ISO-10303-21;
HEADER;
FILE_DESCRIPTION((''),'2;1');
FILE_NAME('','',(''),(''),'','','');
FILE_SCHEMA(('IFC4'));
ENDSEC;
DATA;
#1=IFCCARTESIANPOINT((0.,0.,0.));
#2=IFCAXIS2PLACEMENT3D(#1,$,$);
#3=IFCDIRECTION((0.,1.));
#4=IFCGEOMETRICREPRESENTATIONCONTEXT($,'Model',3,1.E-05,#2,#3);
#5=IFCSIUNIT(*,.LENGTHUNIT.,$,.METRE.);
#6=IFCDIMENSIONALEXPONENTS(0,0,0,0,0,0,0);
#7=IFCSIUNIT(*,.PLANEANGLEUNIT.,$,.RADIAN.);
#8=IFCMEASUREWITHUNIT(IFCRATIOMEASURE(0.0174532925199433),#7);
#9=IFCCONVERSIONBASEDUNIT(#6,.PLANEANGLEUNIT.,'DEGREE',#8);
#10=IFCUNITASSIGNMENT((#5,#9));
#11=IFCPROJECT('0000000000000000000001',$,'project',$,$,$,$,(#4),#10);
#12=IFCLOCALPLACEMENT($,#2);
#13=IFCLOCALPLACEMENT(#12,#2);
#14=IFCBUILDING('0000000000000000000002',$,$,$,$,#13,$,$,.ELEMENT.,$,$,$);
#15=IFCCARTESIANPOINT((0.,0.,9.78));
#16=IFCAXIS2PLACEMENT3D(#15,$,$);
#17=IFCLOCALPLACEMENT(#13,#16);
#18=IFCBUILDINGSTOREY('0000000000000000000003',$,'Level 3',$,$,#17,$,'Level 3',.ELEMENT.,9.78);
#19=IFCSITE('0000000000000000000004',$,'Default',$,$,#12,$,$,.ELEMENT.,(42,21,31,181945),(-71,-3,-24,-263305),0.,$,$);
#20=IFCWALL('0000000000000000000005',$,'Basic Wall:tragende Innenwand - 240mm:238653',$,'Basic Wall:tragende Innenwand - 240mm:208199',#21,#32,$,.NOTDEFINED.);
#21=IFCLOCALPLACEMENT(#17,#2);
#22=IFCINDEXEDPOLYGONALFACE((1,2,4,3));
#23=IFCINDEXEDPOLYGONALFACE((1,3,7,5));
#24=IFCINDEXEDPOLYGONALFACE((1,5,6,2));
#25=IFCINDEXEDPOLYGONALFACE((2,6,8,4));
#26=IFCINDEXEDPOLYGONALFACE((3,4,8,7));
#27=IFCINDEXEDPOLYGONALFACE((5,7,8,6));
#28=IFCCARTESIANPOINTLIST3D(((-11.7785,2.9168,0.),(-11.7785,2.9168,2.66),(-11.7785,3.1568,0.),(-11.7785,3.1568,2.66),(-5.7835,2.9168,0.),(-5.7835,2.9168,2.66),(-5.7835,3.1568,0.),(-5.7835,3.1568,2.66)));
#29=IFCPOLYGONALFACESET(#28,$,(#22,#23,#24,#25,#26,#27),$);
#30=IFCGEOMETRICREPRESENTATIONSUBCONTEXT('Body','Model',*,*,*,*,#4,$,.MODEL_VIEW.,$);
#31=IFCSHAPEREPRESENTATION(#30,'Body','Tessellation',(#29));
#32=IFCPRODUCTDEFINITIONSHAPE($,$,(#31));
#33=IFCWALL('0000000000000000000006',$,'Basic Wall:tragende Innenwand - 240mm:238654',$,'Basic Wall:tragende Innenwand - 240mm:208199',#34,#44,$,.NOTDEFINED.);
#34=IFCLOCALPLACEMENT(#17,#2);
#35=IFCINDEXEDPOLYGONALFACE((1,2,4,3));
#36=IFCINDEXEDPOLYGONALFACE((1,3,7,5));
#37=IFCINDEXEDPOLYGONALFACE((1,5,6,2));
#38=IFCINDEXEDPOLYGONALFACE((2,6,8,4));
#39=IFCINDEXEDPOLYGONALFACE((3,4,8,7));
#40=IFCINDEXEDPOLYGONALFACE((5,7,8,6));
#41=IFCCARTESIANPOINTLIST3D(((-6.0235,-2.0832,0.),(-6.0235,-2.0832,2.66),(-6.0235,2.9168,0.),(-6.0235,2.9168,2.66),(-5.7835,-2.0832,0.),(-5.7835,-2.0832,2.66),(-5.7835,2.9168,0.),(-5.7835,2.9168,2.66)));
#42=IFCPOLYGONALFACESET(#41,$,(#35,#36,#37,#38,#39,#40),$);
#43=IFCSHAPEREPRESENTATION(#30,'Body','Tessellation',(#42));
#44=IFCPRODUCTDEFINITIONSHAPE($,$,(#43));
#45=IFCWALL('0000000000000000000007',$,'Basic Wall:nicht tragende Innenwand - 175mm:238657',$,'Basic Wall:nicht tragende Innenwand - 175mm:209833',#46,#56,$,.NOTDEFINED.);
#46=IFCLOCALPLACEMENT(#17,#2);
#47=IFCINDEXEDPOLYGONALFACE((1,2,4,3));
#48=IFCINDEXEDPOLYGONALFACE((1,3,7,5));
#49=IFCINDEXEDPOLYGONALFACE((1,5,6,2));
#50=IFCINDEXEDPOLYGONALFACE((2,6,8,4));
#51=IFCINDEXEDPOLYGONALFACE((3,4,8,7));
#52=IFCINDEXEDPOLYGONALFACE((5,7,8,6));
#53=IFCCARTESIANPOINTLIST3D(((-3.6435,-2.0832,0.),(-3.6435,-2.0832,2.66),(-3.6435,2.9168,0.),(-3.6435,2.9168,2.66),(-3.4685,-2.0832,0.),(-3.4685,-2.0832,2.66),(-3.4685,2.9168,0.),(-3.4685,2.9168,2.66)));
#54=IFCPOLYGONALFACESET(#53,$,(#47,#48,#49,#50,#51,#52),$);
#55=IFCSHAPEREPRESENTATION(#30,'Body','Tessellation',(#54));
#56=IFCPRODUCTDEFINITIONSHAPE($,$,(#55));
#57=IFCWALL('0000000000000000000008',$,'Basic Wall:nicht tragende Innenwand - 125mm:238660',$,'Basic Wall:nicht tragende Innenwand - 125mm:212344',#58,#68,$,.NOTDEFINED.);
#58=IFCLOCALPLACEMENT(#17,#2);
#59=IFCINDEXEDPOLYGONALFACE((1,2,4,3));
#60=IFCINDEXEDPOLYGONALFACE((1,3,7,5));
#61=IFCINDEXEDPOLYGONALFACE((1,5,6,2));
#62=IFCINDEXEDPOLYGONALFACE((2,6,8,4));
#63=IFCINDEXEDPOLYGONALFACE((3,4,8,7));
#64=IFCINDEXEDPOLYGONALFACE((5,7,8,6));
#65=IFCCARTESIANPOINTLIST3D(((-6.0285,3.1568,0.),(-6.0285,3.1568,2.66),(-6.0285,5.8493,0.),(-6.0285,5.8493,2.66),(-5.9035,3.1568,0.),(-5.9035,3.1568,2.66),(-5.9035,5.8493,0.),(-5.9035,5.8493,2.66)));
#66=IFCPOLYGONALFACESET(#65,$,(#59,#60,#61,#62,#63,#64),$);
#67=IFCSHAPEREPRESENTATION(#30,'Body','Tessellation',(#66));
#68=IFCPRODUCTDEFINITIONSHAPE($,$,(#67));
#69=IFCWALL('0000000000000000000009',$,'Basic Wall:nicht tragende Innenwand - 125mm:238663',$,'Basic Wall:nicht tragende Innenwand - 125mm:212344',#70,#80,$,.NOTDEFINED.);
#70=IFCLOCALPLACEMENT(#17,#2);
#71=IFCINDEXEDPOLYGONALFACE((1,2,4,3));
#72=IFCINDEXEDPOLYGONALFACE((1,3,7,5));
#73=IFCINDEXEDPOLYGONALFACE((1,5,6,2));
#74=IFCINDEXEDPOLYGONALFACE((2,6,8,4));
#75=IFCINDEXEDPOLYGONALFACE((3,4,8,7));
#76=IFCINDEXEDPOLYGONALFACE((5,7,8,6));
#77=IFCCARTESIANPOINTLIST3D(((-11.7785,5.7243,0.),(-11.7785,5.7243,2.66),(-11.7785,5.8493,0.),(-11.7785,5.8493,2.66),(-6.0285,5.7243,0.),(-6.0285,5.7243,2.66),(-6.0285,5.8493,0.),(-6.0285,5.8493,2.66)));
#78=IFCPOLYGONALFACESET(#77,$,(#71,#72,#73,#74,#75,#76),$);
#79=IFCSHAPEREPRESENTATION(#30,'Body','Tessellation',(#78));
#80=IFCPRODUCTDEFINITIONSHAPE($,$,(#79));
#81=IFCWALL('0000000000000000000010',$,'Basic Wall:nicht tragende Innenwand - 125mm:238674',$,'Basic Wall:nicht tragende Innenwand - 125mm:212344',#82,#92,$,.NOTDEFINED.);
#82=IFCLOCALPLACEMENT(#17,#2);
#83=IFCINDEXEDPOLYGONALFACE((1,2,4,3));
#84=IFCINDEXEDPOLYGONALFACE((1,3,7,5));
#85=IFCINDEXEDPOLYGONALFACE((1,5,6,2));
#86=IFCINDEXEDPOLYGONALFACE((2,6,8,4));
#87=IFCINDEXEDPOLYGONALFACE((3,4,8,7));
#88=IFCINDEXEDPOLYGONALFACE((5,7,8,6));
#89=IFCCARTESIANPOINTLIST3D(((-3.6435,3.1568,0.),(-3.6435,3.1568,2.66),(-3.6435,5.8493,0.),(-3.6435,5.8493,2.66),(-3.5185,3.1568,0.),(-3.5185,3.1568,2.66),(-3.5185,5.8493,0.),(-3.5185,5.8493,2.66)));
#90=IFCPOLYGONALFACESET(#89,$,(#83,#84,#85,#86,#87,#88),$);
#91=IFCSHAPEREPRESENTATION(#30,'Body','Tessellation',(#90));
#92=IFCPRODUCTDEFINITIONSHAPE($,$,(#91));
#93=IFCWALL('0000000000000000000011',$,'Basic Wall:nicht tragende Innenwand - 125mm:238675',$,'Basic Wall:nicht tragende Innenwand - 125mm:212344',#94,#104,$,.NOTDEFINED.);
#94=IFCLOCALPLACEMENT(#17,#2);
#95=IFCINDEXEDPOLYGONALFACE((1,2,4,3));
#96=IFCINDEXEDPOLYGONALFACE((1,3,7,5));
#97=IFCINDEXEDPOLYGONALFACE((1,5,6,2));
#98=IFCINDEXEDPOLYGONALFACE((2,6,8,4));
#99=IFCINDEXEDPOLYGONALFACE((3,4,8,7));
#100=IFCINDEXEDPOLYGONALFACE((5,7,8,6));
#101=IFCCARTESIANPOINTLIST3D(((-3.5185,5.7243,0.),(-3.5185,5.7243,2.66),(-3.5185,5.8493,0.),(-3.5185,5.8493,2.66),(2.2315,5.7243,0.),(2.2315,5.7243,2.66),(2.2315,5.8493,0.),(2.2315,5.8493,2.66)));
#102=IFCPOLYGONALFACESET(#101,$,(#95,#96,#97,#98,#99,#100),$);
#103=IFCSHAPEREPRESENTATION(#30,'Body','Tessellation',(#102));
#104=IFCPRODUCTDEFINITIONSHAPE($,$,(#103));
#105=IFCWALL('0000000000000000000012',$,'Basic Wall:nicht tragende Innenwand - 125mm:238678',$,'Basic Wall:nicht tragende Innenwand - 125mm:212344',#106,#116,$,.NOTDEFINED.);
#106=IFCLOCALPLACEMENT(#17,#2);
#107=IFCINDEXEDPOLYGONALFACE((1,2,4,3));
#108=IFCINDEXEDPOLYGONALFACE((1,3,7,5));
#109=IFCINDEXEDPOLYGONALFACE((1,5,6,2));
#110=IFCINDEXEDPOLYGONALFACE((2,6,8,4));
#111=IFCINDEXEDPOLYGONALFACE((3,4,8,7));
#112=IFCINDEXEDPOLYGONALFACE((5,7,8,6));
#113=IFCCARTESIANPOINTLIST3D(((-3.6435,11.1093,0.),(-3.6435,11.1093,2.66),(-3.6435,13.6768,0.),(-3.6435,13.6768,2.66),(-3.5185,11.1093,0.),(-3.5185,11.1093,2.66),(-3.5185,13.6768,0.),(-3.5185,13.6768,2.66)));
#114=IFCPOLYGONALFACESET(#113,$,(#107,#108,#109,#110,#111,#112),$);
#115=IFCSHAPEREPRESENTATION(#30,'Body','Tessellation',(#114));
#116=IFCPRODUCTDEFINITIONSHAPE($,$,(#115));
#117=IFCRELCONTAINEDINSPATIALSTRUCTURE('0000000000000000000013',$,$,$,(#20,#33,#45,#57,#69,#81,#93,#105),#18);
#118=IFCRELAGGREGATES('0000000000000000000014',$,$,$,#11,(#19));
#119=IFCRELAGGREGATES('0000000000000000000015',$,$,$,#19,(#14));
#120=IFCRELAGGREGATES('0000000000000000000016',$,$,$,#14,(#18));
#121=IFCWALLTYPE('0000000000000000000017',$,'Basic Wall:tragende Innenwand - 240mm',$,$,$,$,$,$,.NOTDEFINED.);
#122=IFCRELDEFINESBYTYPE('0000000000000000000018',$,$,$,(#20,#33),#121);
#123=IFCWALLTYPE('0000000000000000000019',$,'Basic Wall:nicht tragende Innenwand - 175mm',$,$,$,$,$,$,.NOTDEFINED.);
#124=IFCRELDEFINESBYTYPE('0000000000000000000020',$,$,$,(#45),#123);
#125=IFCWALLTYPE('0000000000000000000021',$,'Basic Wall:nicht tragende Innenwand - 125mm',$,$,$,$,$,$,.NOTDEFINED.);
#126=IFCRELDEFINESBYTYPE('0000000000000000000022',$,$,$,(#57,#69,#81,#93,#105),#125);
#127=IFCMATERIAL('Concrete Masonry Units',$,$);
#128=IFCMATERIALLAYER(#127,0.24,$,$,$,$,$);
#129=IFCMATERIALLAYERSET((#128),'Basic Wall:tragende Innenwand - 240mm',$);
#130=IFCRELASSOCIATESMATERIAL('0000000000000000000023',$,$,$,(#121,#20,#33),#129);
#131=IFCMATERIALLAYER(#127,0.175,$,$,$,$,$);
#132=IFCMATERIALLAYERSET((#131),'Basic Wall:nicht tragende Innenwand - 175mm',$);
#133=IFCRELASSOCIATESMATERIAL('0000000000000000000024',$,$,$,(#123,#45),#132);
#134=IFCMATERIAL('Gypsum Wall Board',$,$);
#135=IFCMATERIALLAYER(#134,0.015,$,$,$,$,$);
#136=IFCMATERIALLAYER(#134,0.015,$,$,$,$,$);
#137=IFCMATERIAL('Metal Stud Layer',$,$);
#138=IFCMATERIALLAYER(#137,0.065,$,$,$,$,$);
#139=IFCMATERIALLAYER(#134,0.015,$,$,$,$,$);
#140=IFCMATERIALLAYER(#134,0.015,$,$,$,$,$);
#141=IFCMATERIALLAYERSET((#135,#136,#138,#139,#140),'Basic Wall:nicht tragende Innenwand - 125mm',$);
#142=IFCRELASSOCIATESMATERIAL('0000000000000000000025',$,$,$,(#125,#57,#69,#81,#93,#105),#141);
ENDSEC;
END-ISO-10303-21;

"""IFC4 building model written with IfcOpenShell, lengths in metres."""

from ifc_helpers import new_model, entity, si_unit, converted_unit, direction, frame, frame_2d, origin, place, context, subcontext, project, spatial, rectangle, extrude, material, layer, layer_set, layer_usage, type_object, element, save


model = new_model("IFC4")

# Units and contexts
model_context = context("Model", 3, precision=1e-05, world=origin(), true_north=direction((0.0, 1.0)))
body_context = subcontext(model_context, "Body", "Model", "MODEL_VIEW")
ifc_project = project(units=[si_unit("LENGTHUNIT", "METRE"), converted_unit("PLANEANGLEUNIT", "DEGREE", entity("IfcRatioMeasure", 0.0174532925199433), si_unit("PLANEANGLEUNIT", "RADIAN"), dimensions=[0, 0, 0, 0, 0, 0, 0])], contexts=[model_context])

# Site, building, storey
site_placement = place(None, origin())
site = spatial("IfcSite", under=ifc_project, at=site_placement, Name="Default", CompositionType="ELEMENT", RefLatitude=(42, 21, 31, 181945), RefLongitude=(-71, -3, -24, -263305), RefElevation=0.0)
building_placement = place(site_placement, origin())
building = spatial("IfcBuilding", under=site, at=building_placement, CompositionType="ELEMENT")
storey_placement = place(building_placement, frame((0.0, 0.0, 9.78)))
storey = spatial("IfcBuildingStorey", under=building, at=storey_placement, Name="Level 3", LongName="Level 3", CompositionType="ELEMENT", Elevation=9.78)

# Walls
ifc_material_1 = material(Name="Concrete Masonry Units")
ifc_layer_1 = layer(ifc_material_1, 0.24)
ifc_layer_set_1 = layer_set([ifc_layer_1], Name="Basic Wall:tragende Innenwand - 240mm")
ifc_layer_usage_1 = layer_usage(ifc_layer_set_1, "AXIS2", "NEGATIVE", 0.12)
wall_type_1 = type_object("IfcWallType", Name="Basic Wall:tragende Innenwand - 240mm", PredefinedType="NOTDEFINED", material=ifc_layer_set_1)
wall_1_placement = place(storey_placement, frame((-11.7785, 3.0368, 0.0)))
element("IfcWall", 1, at=wall_1_placement, inside=storey, type_object=wall_type_1, material=ifc_layer_usage_1, Name="Basic Wall:tragende Innenwand - 240mm:238653", ObjectType="Basic Wall:tragende Innenwand - 240mm:208199", PredefinedType="NOTDEFINED", context=body_context, shape_type="SweptSolid", body=[
    extrude(rectangle(XDim=5.995, YDim=0.24, at=frame_2d((2.9975, 0.0), x_axis=(-1.0, 0.0))), origin(), (0.0, 0.0, 1.0), 2.66),
])
ifc_layer_usage_2 = layer_usage(ifc_layer_set_1, "AXIS2", "NEGATIVE", 0.12)
wall_2_placement = place(storey_placement, frame((-5.9035, 2.9168, 0.0), z_axis=(0.0, 0.0, 1.0), x_axis=(0.0, -1.0, 0.0)))
element("IfcWall", 2, at=wall_2_placement, inside=storey, type_object=wall_type_1, material=ifc_layer_usage_2, Name="Basic Wall:tragende Innenwand - 240mm:238654", ObjectType="Basic Wall:tragende Innenwand - 240mm:208199", PredefinedType="NOTDEFINED", context=body_context, shape_type="SweptSolid", body=[
    extrude(rectangle(XDim=5.0, YDim=0.24, at=frame_2d((2.5, 0.0), x_axis=(-1.0, 0.0))), origin(), (0.0, 0.0, 1.0), 2.66),
])
ifc_layer_2 = layer(ifc_material_1, 0.175)
ifc_layer_set_2 = layer_set([ifc_layer_2], Name="Basic Wall:nicht tragende Innenwand - 175mm")
ifc_layer_usage_3 = layer_usage(ifc_layer_set_2, "AXIS2", "NEGATIVE", 0.0875)
wall_type_2 = type_object("IfcWallType", Name="Basic Wall:nicht tragende Innenwand - 175mm", PredefinedType="NOTDEFINED", material=ifc_layer_set_2)
wall_3_placement = place(storey_placement, frame((-3.556, 2.9168, 0.0), z_axis=(0.0, 0.0, 1.0), x_axis=(0.0, -1.0, 0.0)))
element("IfcWall", 3, at=wall_3_placement, inside=storey, type_object=wall_type_2, material=ifc_layer_usage_3, Name="Basic Wall:nicht tragende Innenwand - 175mm:238657", ObjectType="Basic Wall:nicht tragende Innenwand - 175mm:209833", PredefinedType="NOTDEFINED", context=body_context, shape_type="SweptSolid", body=[
    extrude(rectangle(XDim=5.0, YDim=0.175, at=frame_2d((2.5, 0.0), x_axis=(-1.0, 0.0))), origin(), (0.0, 0.0, 1.0), 2.66),
])
ifc_material_2 = material(Name="Gypsum Wall Board")
ifc_layer_3 = layer(ifc_material_2, 0.015)
ifc_layer_4 = layer(ifc_material_2, 0.015)
ifc_material_3 = material(Name="Metal Stud Layer")
ifc_layer_5 = layer(ifc_material_3, 0.065)
ifc_layer_6 = layer(ifc_material_2, 0.015)
ifc_layer_7 = layer(ifc_material_2, 0.015)
ifc_layer_set_3 = layer_set([ifc_layer_3, ifc_layer_4, ifc_layer_5, ifc_layer_6, ifc_layer_7], Name="Basic Wall:nicht tragende Innenwand - 125mm")
ifc_layer_usage_4 = layer_usage(ifc_layer_set_3, "AXIS2", "NEGATIVE", 0.0625)
wall_type_3 = type_object("IfcWallType", Name="Basic Wall:nicht tragende Innenwand - 125mm", PredefinedType="NOTDEFINED", material=ifc_layer_set_3)
wall_4_placement = place(storey_placement, frame((-5.966, 5.8493, 0.0), z_axis=(0.0, 0.0, 1.0), x_axis=(0.0, -1.0, 0.0)))
element("IfcWall", 4, at=wall_4_placement, inside=storey, type_object=wall_type_3, material=ifc_layer_usage_4, Name="Basic Wall:nicht tragende Innenwand - 125mm:238660", ObjectType="Basic Wall:nicht tragende Innenwand - 125mm:212344", PredefinedType="NOTDEFINED", context=body_context, shape_type="SweptSolid", body=[
    extrude(rectangle(XDim=2.6925, YDim=0.125, at=frame_2d((1.3462, 0.0), x_axis=(-1.0, 0.0))), origin(), (0.0, 0.0, 1.0), 2.66),
])
ifc_layer_usage_5 = layer_usage(ifc_layer_set_3, "AXIS2", "NEGATIVE", 0.0625)
wall_5_placement = place(storey_placement, frame((-6.0285, 5.7868, 0.0), z_axis=(0.0, 0.0, 1.0), x_axis=(-1.0, 0.0, 0.0)))
element("IfcWall", 5, at=wall_5_placement, inside=storey, type_object=wall_type_3, material=ifc_layer_usage_5, Name="Basic Wall:nicht tragende Innenwand - 125mm:238663", ObjectType="Basic Wall:nicht tragende Innenwand - 125mm:212344", PredefinedType="NOTDEFINED", context=body_context, shape_type="SweptSolid", body=[
    extrude(rectangle(XDim=5.75, YDim=0.125, at=frame_2d((2.875, 0.0), x_axis=(-1.0, 0.0))), origin(), (0.0, 0.0, 1.0), 2.66),
])
ifc_layer_usage_6 = layer_usage(ifc_layer_set_3, "AXIS2", "POSITIVE", -0.0625)
wall_6_placement = place(storey_placement, frame((-3.581, 5.8493, 0.0), z_axis=(0.0, 0.0, 1.0), x_axis=(0.0, -1.0, 0.0)))
element("IfcWall", 6, at=wall_6_placement, inside=storey, type_object=wall_type_3, material=ifc_layer_usage_6, Name="Basic Wall:nicht tragende Innenwand - 125mm:238674", ObjectType="Basic Wall:nicht tragende Innenwand - 125mm:212344", PredefinedType="NOTDEFINED", context=body_context, shape_type="SweptSolid", body=[
    extrude(rectangle(XDim=2.6925, YDim=0.125, at=frame_2d((1.3462, 0.0), x_axis=(-1.0, 0.0))), origin(), (0.0, 0.0, 1.0), 2.66),
])
ifc_layer_usage_7 = layer_usage(ifc_layer_set_3, "AXIS2", "POSITIVE", -0.0625)
wall_7_placement = place(storey_placement, frame((-3.5185, 5.7868, 0.0)))
element("IfcWall", 7, at=wall_7_placement, inside=storey, type_object=wall_type_3, material=ifc_layer_usage_7, Name="Basic Wall:nicht tragende Innenwand - 125mm:238675", ObjectType="Basic Wall:nicht tragende Innenwand - 125mm:212344", PredefinedType="NOTDEFINED", context=body_context, shape_type="SweptSolid", body=[
    extrude(rectangle(XDim=5.75, YDim=0.125, at=frame_2d((2.875, 0.0), x_axis=(-1.0, 0.0))), origin(), (0.0, 0.0, 1.0), 2.66),
])
ifc_layer_usage_8 = layer_usage(ifc_layer_set_3, "AXIS2", "NEGATIVE", 0.0625)
wall_8_placement = place(storey_placement, frame((-3.581, 11.1093, 0.0), z_axis=(0.0, 0.0, 1.0), x_axis=(0.0, 1.0, 0.0)))
element("IfcWall", 8, at=wall_8_placement, inside=storey, type_object=wall_type_3, material=ifc_layer_usage_8, Name="Basic Wall:nicht tragende Innenwand - 125mm:238678", ObjectType="Basic Wall:nicht tragende Innenwand - 125mm:212344", PredefinedType="NOTDEFINED", context=body_context, shape_type="SweptSolid", body=[
    extrude(rectangle(XDim=2.5675, YDim=0.125, at=frame_2d((1.2837, 0.0), x_axis=(-1.0, 0.0))), origin(), (0.0, 0.0, 1.0), 2.66),
])

save(model, "model.ifc")
